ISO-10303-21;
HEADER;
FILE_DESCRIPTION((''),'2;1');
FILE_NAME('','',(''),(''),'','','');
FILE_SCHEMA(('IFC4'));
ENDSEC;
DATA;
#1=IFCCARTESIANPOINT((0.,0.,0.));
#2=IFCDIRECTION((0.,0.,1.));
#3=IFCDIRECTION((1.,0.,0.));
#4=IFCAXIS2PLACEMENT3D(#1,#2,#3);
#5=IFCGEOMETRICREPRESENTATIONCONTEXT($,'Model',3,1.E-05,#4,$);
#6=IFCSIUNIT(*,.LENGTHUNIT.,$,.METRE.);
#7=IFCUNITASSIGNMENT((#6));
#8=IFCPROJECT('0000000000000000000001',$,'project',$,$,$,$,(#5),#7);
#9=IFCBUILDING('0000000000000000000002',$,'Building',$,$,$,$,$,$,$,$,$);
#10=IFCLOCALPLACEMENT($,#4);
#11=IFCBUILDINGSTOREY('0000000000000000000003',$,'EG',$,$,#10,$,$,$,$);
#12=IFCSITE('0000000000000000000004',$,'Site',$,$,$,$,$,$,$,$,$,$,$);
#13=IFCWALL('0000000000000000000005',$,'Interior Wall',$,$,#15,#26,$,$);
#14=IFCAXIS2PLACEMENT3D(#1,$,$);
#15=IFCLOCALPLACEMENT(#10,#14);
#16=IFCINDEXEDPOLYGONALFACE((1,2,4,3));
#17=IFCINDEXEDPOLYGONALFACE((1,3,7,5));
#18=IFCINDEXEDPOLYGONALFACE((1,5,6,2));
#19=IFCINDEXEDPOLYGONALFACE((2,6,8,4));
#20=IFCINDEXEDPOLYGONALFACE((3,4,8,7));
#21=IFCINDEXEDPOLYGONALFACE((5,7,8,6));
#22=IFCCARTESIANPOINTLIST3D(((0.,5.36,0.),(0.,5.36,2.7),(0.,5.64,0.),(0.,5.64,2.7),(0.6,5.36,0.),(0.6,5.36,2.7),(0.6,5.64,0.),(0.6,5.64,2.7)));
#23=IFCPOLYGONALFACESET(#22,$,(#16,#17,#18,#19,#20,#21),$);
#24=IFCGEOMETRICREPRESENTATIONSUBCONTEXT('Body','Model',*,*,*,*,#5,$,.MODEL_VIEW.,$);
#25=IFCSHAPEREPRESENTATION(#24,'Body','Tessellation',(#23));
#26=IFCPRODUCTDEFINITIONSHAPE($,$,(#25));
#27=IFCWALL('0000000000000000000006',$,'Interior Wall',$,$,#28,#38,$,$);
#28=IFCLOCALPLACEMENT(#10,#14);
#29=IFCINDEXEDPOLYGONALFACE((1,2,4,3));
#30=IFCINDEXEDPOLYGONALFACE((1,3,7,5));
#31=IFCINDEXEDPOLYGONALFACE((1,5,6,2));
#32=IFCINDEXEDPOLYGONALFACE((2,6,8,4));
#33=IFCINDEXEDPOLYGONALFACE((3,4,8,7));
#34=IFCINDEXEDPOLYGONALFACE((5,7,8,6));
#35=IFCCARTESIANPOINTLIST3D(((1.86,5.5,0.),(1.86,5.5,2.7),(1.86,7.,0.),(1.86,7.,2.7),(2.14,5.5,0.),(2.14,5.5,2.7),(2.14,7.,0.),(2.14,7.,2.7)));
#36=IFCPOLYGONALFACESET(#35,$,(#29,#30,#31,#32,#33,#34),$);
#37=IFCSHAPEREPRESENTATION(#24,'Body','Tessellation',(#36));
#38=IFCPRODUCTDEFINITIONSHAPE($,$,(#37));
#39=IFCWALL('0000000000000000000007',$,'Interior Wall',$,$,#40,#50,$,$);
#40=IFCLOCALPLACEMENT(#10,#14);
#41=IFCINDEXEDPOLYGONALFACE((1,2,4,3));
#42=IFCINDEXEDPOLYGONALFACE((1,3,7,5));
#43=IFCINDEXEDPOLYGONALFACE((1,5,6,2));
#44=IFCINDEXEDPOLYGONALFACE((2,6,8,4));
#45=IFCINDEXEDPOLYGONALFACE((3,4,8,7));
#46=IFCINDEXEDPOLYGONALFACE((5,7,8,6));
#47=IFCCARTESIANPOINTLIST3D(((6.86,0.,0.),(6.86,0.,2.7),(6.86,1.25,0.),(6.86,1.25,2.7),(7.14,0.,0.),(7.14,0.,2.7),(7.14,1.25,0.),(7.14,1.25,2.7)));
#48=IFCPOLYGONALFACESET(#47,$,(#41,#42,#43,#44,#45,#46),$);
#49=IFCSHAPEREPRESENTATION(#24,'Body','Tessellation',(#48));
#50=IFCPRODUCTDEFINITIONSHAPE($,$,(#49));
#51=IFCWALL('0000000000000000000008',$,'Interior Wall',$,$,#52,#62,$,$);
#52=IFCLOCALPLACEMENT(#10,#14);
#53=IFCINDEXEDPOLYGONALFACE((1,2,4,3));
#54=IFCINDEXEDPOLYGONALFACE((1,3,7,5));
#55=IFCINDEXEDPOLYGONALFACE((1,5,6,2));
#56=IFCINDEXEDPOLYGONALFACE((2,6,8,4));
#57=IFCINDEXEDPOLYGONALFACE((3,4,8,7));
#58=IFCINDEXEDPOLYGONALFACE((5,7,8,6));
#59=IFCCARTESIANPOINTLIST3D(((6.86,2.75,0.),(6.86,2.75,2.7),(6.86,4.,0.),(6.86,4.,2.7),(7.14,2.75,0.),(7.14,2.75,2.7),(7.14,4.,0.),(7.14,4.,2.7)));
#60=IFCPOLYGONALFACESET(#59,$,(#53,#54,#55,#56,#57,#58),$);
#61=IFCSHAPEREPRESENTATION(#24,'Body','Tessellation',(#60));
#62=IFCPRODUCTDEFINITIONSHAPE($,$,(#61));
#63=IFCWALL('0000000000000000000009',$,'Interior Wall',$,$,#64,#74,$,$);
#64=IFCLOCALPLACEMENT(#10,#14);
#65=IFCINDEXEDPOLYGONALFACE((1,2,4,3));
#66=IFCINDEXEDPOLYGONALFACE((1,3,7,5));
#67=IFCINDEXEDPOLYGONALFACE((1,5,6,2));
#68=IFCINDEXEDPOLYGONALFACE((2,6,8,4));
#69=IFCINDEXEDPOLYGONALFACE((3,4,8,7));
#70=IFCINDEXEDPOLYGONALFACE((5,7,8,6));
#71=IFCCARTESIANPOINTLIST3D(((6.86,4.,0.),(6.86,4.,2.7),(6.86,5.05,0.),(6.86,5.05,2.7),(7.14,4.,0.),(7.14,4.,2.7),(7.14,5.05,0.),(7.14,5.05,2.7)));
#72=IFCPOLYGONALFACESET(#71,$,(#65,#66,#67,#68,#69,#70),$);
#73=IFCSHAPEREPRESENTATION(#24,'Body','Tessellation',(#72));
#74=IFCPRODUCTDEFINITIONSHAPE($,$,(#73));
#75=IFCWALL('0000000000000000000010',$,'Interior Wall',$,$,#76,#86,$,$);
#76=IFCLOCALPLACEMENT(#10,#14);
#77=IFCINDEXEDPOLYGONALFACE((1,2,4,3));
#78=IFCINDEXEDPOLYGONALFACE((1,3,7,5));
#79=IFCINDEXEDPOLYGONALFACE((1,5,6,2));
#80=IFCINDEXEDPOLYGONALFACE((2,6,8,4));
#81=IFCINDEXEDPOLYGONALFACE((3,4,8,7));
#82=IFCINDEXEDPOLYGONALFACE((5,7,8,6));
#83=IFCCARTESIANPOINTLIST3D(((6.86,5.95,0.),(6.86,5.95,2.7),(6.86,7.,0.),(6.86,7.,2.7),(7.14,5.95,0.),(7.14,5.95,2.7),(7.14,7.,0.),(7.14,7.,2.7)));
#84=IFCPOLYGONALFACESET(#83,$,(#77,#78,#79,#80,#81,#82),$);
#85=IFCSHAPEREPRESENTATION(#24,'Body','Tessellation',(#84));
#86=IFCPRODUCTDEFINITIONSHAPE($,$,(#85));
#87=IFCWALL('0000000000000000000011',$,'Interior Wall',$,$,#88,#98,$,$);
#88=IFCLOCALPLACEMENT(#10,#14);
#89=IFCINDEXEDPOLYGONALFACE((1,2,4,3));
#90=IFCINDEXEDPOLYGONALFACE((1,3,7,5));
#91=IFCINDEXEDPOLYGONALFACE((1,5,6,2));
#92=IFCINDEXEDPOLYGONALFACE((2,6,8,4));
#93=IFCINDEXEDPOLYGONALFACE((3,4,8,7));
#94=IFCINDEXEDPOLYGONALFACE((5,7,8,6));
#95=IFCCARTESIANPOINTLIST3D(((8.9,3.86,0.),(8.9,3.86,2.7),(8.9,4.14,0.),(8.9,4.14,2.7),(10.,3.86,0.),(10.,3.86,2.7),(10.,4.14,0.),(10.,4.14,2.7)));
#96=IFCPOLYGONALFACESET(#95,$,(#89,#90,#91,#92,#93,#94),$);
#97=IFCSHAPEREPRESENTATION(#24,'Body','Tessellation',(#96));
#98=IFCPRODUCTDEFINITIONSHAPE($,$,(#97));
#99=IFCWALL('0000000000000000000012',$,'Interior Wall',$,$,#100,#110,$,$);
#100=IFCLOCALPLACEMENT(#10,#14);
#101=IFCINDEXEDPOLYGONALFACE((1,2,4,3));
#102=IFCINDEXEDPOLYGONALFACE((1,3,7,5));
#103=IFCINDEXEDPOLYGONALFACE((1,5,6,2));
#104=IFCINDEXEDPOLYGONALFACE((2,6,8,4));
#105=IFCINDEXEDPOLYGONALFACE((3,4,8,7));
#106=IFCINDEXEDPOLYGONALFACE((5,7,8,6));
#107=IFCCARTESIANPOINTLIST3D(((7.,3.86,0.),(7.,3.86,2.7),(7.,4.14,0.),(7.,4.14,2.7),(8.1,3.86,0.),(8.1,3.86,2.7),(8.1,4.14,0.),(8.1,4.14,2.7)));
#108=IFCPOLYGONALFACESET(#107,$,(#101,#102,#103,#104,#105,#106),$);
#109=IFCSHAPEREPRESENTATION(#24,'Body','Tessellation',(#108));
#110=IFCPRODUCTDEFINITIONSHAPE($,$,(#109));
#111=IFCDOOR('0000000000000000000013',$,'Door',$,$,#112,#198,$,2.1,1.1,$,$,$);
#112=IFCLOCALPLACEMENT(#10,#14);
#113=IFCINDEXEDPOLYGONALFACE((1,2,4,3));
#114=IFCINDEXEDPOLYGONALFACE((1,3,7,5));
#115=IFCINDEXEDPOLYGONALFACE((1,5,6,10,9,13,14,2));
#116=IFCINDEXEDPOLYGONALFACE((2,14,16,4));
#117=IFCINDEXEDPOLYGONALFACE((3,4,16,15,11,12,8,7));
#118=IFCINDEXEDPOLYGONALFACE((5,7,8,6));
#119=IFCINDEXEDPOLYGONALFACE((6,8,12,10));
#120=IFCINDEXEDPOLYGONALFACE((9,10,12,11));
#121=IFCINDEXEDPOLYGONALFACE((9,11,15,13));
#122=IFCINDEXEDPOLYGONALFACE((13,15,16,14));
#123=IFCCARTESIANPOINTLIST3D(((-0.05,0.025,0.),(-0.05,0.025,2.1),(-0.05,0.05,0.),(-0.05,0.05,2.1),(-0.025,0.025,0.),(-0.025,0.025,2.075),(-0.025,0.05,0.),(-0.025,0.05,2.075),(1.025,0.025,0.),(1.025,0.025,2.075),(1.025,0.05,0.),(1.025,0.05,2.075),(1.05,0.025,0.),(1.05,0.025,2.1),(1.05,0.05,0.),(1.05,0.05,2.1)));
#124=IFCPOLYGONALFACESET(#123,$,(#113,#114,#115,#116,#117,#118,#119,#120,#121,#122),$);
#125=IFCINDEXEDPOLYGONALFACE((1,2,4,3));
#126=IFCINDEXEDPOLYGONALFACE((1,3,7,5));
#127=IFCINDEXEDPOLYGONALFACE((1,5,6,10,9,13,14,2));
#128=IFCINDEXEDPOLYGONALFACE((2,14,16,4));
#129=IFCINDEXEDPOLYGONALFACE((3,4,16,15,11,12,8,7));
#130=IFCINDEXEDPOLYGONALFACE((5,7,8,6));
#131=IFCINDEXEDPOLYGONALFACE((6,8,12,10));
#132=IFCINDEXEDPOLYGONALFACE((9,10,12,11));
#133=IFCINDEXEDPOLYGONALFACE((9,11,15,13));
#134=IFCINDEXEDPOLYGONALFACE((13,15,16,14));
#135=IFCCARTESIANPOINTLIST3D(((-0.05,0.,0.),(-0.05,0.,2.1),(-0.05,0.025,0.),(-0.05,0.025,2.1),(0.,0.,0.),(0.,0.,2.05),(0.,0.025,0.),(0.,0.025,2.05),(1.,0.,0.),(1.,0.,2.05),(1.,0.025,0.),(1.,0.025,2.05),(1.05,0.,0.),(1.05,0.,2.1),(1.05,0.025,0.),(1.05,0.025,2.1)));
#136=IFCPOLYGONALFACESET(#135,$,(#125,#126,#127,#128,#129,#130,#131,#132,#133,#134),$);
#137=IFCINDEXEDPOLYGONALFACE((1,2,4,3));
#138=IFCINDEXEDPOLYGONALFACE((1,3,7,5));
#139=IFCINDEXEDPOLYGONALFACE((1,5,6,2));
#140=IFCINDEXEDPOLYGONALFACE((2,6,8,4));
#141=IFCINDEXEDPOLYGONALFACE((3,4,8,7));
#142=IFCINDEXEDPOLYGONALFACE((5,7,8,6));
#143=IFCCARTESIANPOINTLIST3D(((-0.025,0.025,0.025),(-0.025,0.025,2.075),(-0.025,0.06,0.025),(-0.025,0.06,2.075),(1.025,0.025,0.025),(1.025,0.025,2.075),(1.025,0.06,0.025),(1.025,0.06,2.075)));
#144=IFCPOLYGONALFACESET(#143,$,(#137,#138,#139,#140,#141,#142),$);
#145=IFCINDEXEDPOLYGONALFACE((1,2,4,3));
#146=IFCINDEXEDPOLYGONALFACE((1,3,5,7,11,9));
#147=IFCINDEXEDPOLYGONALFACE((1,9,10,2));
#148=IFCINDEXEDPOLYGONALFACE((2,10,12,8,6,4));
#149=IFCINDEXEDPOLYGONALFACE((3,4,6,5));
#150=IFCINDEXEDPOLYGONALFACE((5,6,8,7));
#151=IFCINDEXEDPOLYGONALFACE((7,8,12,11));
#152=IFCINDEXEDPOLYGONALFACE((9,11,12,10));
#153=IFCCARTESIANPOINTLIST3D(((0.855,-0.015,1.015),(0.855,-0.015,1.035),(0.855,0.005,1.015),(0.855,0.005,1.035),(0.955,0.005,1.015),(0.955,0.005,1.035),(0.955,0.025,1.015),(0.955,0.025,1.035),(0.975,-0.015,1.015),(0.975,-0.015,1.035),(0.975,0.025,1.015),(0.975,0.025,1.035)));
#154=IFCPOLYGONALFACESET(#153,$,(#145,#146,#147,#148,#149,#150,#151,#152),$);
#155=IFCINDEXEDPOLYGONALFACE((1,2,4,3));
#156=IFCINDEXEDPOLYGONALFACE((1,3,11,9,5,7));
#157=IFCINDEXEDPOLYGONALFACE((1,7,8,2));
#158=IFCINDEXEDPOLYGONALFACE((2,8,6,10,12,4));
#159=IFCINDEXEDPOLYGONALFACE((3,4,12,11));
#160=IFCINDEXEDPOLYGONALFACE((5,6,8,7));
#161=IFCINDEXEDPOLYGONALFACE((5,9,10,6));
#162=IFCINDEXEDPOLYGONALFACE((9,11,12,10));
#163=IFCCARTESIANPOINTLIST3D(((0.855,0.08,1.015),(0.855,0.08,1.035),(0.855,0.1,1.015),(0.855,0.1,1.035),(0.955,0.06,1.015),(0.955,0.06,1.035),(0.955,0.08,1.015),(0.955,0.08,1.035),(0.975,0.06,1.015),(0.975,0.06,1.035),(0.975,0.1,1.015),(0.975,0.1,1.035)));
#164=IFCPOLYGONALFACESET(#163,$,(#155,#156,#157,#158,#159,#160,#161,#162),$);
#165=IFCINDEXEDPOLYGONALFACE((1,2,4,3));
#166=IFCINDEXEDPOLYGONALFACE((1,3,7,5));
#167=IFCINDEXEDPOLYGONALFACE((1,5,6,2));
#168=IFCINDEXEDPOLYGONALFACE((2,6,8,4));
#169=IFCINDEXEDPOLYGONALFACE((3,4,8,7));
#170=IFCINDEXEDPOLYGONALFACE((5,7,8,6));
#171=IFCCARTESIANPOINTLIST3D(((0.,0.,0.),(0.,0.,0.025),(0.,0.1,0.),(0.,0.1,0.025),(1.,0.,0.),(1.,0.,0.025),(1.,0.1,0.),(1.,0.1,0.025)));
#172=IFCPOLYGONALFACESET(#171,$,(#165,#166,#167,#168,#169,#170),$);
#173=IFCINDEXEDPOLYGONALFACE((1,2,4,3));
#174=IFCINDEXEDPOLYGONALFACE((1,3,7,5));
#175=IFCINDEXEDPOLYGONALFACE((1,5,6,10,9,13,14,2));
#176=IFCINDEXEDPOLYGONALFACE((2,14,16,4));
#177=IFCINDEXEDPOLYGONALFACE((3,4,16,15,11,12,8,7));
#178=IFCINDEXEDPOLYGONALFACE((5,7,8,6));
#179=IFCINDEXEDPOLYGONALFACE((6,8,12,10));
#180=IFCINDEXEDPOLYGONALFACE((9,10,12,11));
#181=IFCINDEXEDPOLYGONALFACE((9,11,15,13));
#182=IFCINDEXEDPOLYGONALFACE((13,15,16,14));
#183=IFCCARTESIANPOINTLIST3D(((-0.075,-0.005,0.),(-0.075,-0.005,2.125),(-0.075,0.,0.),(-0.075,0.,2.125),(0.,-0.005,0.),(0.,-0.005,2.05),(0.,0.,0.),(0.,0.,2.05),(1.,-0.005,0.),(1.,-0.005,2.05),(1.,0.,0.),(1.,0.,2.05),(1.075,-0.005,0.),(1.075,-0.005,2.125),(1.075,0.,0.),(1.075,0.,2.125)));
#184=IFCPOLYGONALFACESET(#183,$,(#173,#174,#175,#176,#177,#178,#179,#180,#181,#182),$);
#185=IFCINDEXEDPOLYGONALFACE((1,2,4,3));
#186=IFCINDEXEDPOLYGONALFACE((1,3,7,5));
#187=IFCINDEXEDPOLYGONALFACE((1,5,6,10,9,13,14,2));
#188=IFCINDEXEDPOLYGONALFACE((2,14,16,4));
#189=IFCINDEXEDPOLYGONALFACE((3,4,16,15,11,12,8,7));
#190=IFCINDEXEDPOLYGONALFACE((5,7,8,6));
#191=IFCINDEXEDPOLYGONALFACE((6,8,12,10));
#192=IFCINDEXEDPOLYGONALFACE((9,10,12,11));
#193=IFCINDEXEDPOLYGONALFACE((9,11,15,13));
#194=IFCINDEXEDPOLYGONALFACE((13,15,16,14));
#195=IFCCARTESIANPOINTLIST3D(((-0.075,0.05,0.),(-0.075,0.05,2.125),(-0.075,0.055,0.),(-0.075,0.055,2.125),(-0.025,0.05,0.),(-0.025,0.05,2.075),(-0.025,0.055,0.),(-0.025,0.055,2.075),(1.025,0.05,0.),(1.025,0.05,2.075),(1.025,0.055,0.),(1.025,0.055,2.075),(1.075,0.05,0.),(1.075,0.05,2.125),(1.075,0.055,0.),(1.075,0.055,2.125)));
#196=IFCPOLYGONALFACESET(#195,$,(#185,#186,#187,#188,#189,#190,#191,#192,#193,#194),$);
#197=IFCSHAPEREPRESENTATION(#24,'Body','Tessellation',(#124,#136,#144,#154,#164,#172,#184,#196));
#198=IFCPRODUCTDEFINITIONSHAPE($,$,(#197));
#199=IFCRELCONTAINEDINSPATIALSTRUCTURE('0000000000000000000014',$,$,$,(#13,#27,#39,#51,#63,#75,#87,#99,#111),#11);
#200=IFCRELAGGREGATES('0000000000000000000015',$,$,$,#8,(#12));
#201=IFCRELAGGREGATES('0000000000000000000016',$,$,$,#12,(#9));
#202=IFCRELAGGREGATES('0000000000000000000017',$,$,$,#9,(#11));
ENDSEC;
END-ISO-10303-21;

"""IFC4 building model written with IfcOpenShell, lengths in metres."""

from ifc_helpers import new_model, si_unit, frame, origin_with_axes, place, context, subcontext, project, spatial, line, indexed_curve, outline, extrude, element, save


model = new_model("IFC4")

# Units and contexts
model_context = context("Model", 3, precision=1e-05, world=origin_with_axes())
body_context = subcontext(model_context, "Body", "Model", "MODEL_VIEW")
ifc_project = project(units=[si_unit("LENGTHUNIT", "METRE")], contexts=[model_context])

# Site, building, storey
site = spatial("IfcSite", under=ifc_project, Name="Site")
building = spatial("IfcBuilding", under=site, Name="Building")
storey_placement = place(None, origin_with_axes())
storey = spatial("IfcBuildingStorey", under=building, at=storey_placement, Name="EG")

# Walls
for number, where, z_axis, x_axis, name in (
    (1, (0.6, 5.5, 0.0), (0.0, 0.0, 1.0), (-1.0, 0.0, 0.0), "Interior Wall"),
):
    element("IfcWall", number, at=place(storey_placement, frame(where, z_axis=z_axis, x_axis=x_axis)), inside=storey, Name=name, context=body_context, shape_type="SweptSolid", body=[
        extrude(outline(indexed_curve([(0.0, 0.0), (0.0, 0.28), (0.6, 0.28), (0.6, 0.0), (0.0, 0.0)], self_intersect=False)), frame((0.0, -0.14, 0.0), z_axis=(0.0, 0.0, 1.0), x_axis=(1.0, 0.0, 0.0)), (0.0, 0.0, 1.0), 2.7),
    ])
wall_1_placement = place(storey_placement, frame((2.0, 5.5, 0.0), z_axis=(0.0, 0.0, 1.0), x_axis=(0.0, 1.0, 0.0)))
element("IfcWall", 2, at=wall_1_placement, inside=storey, Name="Interior Wall", context=body_context, shape_type="SweptSolid", body=[
    extrude(outline(indexed_curve([(0.0, 0.0), (0.0, 0.28), (1.5, 0.28), (1.5, 0.0), (0.0, 0.0)], self_intersect=False)), frame((0.0, -0.14, 0.0), z_axis=(0.0, 0.0, 1.0), x_axis=(1.0, 0.0, 0.0)), (0.0, 0.0, 1.0), 2.7),
])
for number, where, z_axis, x_axis, name in (
    (3, (7.0, 0.0, 0.0), (0.0, 0.0, 1.0), (0.0, 1.0, 0.0), "Interior Wall"),
    (4, (7.0, 2.75, 0.0), (0.0, 0.0, 1.0), (0.0, 1.0, 0.0), "Interior Wall"),
):
    element("IfcWall", number, at=place(storey_placement, frame(where, z_axis=z_axis, x_axis=x_axis)), inside=storey, Name=name, context=body_context, shape_type="SweptSolid", body=[
        extrude(outline(indexed_curve([(0.0, 0.0), (0.0, 0.28), (1.25, 0.28), (1.25, 0.0), (0.0, 0.0)], self_intersect=False)), frame((0.0, -0.14, 0.0), z_axis=(0.0, 0.0, 1.0), x_axis=(1.0, 0.0, 0.0)), (0.0, 0.0, 1.0), 2.7),
    ])
for number, where, z_axis, x_axis, name in (
    (5, (7.0, 4.0, 0.0), (0.0, 0.0, 1.0), (0.0, 1.0, 0.0), "Interior Wall"),
    (6, (7.0, 5.95, 0.0), (0.0, 0.0, 1.0), (0.0, 1.0, 0.0), "Interior Wall"),
):
    element("IfcWall", number, at=place(storey_placement, frame(where, z_axis=z_axis, x_axis=x_axis)), inside=storey, Name=name, context=body_context, shape_type="SweptSolid", body=[
        extrude(outline(indexed_curve([(0.0, 0.0), (0.0, 0.28), (1.05, 0.28), (1.05, 0.0), (0.0, 0.0)], self_intersect=False)), frame((0.0, -0.14, 0.0), z_axis=(0.0, 0.0, 1.0), x_axis=(1.0, 0.0, 0.0)), (0.0, 0.0, 1.0), 2.7),
    ])
for number, where, z_axis, x_axis, name in (
    (7, (10.0, 4.0, 0.0), (0.0, 0.0, 1.0), (-1.0, 0.0, 0.0), "Interior Wall"),
    (8, (8.1, 4.0, 0.0), (0.0, 0.0, 1.0), (-1.0, 0.0, 0.0), "Interior Wall"),
):
    element("IfcWall", number, at=place(storey_placement, frame(where, z_axis=z_axis, x_axis=x_axis)), inside=storey, Name=name, context=body_context, shape_type="SweptSolid", body=[
        extrude(outline(indexed_curve([(0.0, 0.0), (0.0, 0.28), (1.1, 0.28), (1.1, 0.0), (0.0, 0.0)], self_intersect=False)), frame((0.0, -0.14, 0.0), z_axis=(0.0, 0.0, 1.0), x_axis=(1.0, 0.0, 0.0)), (0.0, 0.0, 1.0), 2.7),
    ])

# Door
door_1_placement = place(storey_placement, frame((-0.05, 0.0, 0.0), z_axis=(0.0, 0.0, 1.0), x_axis=(1.0, 0.0, 0.0)))
element("IfcDoor", 9, at=door_1_placement, inside=storey, Name="Door", OverallHeight=2.1, OverallWidth=1.1, context=body_context, shape_type="SweptSolid", body=[
    extrude(outline(indexed_curve([(0.0, 0.0), (0.0, 2.1), (1.1, 2.1), (1.1, 0.0), (1.075, 0.0), (1.075, 2.075), (0.025, 2.075), (0.025, 0.0)], segments=[line(1, 2, 3, 4, 5, 6, 7, 8, 1)])), frame((0.0, 0.025, 0.0), z_axis=(0.0, -1.0, 0.0), x_axis=(1.0, 0.0, 0.0)), (0.0, 0.0, -1.0), 0.025),
    extrude(outline(indexed_curve([(0.0, 0.0), (0.0, 2.1), (1.1, 2.1), (1.1, 0.0), (1.05, 0.0), (1.05, 2.05), (0.05, 2.05), (0.05, 0.0)], segments=[line(1, 2, 3, 4, 5, 6, 7, 8, 1)])), frame((0.0, 0.0, 0.0), z_axis=(0.0, -1.0, 0.0), x_axis=(1.0, 0.0, 0.0)), (0.0, 0.0, -1.0), 0.025),
    extrude(outline(indexed_curve([(0.0, 0.0), (1.05, 0.0), (1.05, 0.035), (0.0, 0.035)], segments=[line(1, 2, 3, 4, 1)])), frame((0.025, 0.025, 0.025), z_axis=(0.0, 0.0, 1.0), x_axis=(1.0, 0.0, 0.0)), (0.0, 0.0, 1.0), 2.05),
    extrude(outline(indexed_curve([(0.0, 0.0), (0.0, -0.04), (-0.12, -0.04), (-0.12, -0.02), (-0.02, -0.02), (-0.02, 0.0)], segments=[line(1, 2, 3, 4, 5, 6, 1)])), frame((1.025, 0.025, 1.015), z_axis=(0.0, 0.0, 1.0), x_axis=(1.0, 0.0, 0.0)), (0.0, 0.0, 1.0), 0.02),
    extrude(outline(indexed_curve([(0.0, 0.0), (0.0, 0.04), (-0.12, 0.04), (-0.12, 0.02), (-0.02, 0.02), (-0.02, 0.0)], segments=[line(1, 2, 3, 4, 5, 6, 1)])), frame((1.025, 0.06, 1.015), z_axis=(0.0, 0.0, 1.0), x_axis=(1.0, 0.0, 0.0)), (0.0, 0.0, 1.0), 0.02),
    extrude(outline(indexed_curve([(0.0, 0.0), (1.0, 0.0), (1.0, 0.1), (0.0, 0.1)], segments=[line(1, 2, 3, 4, 1)])), frame((0.05, 0.0, 0.0), z_axis=(0.0, 0.0, 1.0), x_axis=(1.0, 0.0, 0.0)), (0.0, 0.0, 1.0), 0.025),
    extrude(outline(indexed_curve([(0.0, 0.0), (0.0, 2.125), (1.15, 2.125), (1.15, 0.0), (1.075, 0.0), (1.075, 2.05), (0.075, 2.05), (0.075, 0.0)], segments=[line(1, 2, 3, 4, 5, 6, 7, 8, 1)])), frame((-0.025, -0.005, 0.0), z_axis=(0.0, -1.0, 0.0), x_axis=(1.0, 0.0, 0.0)), (0.0, 0.0, -1.0), 0.005),
    extrude(outline(indexed_curve([(0.0, 0.0), (0.0, 2.125), (1.15, 2.125), (1.15, 0.0), (1.1, 0.0), (1.1, 2.075), (0.05, 2.075), (0.05, 0.0)], segments=[line(1, 2, 3, 4, 5, 6, 7, 8, 1)])), frame((-0.025, 0.05, 0.0), z_axis=(0.0, -1.0, 0.0), x_axis=(1.0, 0.0, 0.0)), (0.0, 0.0, -1.0), 0.005),
])

save(model, "model.ifc")
